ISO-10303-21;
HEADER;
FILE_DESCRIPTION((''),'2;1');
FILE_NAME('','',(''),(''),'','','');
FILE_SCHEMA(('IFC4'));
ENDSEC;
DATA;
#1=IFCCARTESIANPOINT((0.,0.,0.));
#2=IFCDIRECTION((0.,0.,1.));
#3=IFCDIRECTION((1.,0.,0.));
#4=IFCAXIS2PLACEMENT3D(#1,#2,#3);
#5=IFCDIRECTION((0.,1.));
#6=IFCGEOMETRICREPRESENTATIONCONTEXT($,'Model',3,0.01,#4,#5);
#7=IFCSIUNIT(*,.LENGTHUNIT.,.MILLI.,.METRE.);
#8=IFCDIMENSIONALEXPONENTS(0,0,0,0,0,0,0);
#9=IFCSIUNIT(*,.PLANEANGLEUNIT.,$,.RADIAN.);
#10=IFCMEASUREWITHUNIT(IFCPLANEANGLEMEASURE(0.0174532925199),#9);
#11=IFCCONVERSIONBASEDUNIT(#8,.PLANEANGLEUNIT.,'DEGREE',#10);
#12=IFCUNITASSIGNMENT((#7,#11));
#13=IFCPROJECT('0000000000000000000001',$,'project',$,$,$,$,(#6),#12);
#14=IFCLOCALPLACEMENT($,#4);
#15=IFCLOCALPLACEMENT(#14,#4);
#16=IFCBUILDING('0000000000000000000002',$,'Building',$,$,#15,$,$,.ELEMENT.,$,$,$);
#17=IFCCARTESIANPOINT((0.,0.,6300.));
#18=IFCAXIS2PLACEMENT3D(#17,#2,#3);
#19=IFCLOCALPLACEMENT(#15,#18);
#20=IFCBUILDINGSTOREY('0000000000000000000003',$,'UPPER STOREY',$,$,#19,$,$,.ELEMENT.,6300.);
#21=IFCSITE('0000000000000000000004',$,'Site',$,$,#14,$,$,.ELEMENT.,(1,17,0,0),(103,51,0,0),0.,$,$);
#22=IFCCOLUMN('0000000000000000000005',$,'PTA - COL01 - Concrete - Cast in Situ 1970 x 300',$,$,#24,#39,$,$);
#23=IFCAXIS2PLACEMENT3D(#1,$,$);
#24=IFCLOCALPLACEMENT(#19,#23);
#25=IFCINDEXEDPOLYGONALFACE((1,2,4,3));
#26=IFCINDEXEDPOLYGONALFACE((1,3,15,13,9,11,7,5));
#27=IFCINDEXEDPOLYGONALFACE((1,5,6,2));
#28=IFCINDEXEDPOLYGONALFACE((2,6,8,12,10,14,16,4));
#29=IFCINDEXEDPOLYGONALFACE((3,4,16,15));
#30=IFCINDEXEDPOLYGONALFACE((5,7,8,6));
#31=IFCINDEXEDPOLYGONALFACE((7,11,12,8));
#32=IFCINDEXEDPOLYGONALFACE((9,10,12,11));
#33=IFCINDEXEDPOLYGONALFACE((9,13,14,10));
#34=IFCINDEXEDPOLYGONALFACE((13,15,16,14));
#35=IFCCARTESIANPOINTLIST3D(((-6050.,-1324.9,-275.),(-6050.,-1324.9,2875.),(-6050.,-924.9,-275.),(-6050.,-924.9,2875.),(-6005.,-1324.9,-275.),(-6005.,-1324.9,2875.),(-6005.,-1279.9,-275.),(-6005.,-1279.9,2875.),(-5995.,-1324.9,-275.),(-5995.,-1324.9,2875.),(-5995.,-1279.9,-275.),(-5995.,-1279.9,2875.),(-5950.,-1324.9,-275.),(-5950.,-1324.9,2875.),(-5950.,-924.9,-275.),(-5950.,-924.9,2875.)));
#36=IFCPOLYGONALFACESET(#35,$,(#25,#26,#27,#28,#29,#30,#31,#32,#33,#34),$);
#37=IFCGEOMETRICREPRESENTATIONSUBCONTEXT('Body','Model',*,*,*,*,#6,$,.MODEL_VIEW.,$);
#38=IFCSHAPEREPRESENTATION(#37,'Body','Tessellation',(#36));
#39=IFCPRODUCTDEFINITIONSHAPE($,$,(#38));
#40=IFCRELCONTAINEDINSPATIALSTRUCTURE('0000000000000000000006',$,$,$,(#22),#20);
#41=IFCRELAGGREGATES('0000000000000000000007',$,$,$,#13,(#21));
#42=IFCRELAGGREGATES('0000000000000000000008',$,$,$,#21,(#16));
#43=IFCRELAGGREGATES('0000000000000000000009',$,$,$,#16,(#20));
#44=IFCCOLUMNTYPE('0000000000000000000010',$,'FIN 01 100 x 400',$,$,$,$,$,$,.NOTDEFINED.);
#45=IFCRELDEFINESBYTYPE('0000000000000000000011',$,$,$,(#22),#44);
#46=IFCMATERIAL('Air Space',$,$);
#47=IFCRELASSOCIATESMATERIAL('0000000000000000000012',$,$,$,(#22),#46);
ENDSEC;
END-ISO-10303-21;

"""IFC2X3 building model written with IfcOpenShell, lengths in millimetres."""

from ifc_helpers import new_model, entity, si_unit, converted_unit, direction, frame, origin_with_axes, place, context, subcontext, project, spatial, polyline, outline, extrude, material, type_object, element, save


model = new_model("IFC2X3")

# Units and contexts
model_context = context("Model", 3, precision=0.01, world=origin_with_axes(), true_north=direction((0.0, 1.0)))
body_context = subcontext(model_context, "Body", "Model", "MODEL_VIEW")
ifc_project = project(units=[si_unit("LENGTHUNIT", "METRE", prefix="MILLI"), converted_unit("PLANEANGLEUNIT", "DEGREE", entity("IfcPlaneAngleMeasure", 0.0174532925199), si_unit("PLANEANGLEUNIT", "RADIAN"), dimensions=[0, 0, 0, 0, 0, 0, 0])], contexts=[model_context])

# Site, building, storey
site_placement = place(None, origin_with_axes())
site = spatial("IfcSite", under=ifc_project, at=site_placement, Name="Site", CompositionType="ELEMENT", RefLatitude=(1, 17, 0, 0), RefLongitude=(103, 51, 0, 0), RefElevation=0.0)
building_placement = place(site_placement, origin_with_axes())
building = spatial("IfcBuilding", under=site, at=building_placement, Name="Building", CompositionType="ELEMENT")
storey_placement = place(building_placement, frame((0.0, 0.0, 6300.0), z_axis=(0.0, 0.0, 1.0), x_axis=(1.0, 0.0, 0.0)))
storey = spatial("IfcBuildingStorey", under=building, at=storey_placement, Name="UPPER STOREY", CompositionType="ELEMENT", Elevation=6300.0)

# Column
ifc_material_1 = material(Name="Air Space")
column_type = type_object("IfcColumnType", Name="FIN 01 100 x 400", PredefinedType="NOTDEFINED")
column_placement = place(storey_placement, frame((-5999.9, -1324.9, -275.0), z_axis=(0.0, 0.0, 1.0), x_axis=(-1.0, 0.0, 0.0)))
element("IfcColumn", 1, at=column_placement, inside=storey, type_object=column_type, material=ifc_material_1, Name="PTA - COL01 - Concrete - Cast in Situ 1970 x 300", context=body_context, shape_type="SweptSolid", body=[
    extrude(outline(polyline([(-50.0, 0.0), (-50.0, -400.0), (50.0, -400.0), (50.0, 0.0), (5.0, 0.0), (5.0, -45.0), (-5.0, -45.0), (-5.0, 0.0), (-50.0, 0.0)])), frame((0.0, 0.0, 0.0), z_axis=(0.0, 0.0, -1.0), x_axis=(-1.0, 0.0, 0.0)), (0.0, 0.0, -1.0), 3150.0),
])

save(model, "model.ifc")
